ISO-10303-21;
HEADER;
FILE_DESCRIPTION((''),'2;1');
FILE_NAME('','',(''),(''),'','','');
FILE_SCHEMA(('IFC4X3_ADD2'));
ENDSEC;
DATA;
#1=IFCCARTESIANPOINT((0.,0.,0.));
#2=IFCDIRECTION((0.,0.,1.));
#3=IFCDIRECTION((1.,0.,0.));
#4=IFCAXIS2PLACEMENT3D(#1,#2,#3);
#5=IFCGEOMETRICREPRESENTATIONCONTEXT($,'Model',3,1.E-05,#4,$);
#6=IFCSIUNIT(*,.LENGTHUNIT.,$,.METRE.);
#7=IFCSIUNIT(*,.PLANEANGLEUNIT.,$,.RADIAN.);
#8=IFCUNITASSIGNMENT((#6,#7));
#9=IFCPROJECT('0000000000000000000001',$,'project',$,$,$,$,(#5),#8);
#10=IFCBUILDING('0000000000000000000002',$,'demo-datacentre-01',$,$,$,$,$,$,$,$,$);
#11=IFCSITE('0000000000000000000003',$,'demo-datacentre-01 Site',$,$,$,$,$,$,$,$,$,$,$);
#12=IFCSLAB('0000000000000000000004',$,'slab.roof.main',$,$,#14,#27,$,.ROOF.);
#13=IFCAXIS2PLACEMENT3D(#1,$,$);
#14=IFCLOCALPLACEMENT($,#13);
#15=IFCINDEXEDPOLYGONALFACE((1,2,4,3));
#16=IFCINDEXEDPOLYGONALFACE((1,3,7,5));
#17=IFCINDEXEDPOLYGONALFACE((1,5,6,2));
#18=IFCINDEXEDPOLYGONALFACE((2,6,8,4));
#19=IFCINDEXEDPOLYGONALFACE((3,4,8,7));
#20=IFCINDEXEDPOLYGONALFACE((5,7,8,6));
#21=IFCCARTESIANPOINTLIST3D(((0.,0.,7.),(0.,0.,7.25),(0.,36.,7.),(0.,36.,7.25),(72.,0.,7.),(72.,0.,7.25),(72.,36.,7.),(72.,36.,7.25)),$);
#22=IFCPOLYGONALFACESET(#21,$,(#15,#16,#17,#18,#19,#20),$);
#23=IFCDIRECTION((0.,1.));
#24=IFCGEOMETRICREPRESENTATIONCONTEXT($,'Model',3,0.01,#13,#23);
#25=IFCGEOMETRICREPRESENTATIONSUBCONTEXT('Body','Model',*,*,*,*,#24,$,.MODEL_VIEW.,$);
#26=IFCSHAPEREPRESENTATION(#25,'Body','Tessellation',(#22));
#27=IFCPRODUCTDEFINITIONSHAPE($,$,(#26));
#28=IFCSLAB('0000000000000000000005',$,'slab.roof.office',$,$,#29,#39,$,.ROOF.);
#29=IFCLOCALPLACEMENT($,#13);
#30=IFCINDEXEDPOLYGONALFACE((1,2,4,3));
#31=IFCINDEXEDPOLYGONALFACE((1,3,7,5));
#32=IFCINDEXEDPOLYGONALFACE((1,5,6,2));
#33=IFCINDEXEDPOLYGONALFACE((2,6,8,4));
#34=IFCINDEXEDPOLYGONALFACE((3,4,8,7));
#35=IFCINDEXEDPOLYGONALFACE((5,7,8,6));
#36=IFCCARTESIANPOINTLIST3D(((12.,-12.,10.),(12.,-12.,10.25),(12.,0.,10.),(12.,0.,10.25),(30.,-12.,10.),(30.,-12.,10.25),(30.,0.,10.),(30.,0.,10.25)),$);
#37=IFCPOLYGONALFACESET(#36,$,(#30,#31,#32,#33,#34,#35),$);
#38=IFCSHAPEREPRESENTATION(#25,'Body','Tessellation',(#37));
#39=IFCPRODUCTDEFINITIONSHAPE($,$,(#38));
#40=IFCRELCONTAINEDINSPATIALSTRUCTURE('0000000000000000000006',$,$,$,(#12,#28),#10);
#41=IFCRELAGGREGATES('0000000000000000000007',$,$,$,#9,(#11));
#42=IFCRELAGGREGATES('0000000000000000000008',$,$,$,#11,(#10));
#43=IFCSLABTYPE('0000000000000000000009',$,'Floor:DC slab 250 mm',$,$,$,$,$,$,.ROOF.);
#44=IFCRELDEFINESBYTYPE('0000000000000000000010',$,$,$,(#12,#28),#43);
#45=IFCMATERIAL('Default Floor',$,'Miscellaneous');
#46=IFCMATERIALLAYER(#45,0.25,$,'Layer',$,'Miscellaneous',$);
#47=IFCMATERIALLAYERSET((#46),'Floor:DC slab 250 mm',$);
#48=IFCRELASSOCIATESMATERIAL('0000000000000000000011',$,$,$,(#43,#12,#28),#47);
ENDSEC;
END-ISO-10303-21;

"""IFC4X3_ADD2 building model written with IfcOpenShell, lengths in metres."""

from ifc_helpers import new_model, si_unit, direction, frame, frame_2d, origin, origin_with_axes, origin_2d_with_axis, place, context, subcontext, project, spatial, rectangle, extrude, material, layer, layer_set, layer_usage, type_object, element, save


model = new_model("IFC4X3_ADD2")

# Units and contexts
model_context_1 = context("Model", 3, precision=0.01, world=origin(), true_north=direction((0.0, 1.0)))
model_context_2 = context("Model", 3, precision=1e-05, world=origin_with_axes())
body_context = subcontext(model_context_1, "Body", "Model", "MODEL_VIEW")
ifc_project = project(units=[si_unit("LENGTHUNIT", "METRE"), si_unit("PLANEANGLEUNIT", "RADIAN")], contexts=[model_context_2])

# Site, building
site = spatial("IfcSite", under=ifc_project, Name="demo-datacentre-01 Site")
building = spatial("IfcBuilding", under=site, Name="demo-datacentre-01")

# Slabs
ifc_material = material(Name="Default Floor", Category="Miscellaneous")
ifc_layer = layer(ifc_material, 0.25, Name="Layer", Category="Miscellaneous")
ifc_layer_set = layer_set([ifc_layer], Name="Floor:DC slab 250 mm")
ifc_layer_usage_1 = layer_usage(ifc_layer_set, "AXIS3", "POSITIVE", 0.0)
slab_type = type_object("IfcSlabType", Name="Floor:DC slab 250 mm", PredefinedType="ROOF", material=ifc_layer_set)
placement_1 = place(None, origin())
placement_2 = place(placement_1, origin())
placement_3 = place(placement_2, frame((0.0, 0.0, 7.0)))
slab_1_placement = place(placement_3, origin())
element("IfcSlab", 1, at=slab_1_placement, inside=building, type_object=slab_type, material=ifc_layer_usage_1, Name="slab.roof.main", PredefinedType="ROOF", context=body_context, shape_type="SweptSolid", body=[
    extrude(rectangle(XDim=36.0, YDim=72.0, at=origin_2d_with_axis()), frame((36.0, 18.0, 0.25), z_axis=(0.0, 0.0, -1.0), x_axis=(0.0, 1.0, 0.0)), (0.0, 0.0, 1.0), 0.25),
])
ifc_layer_usage_2 = layer_usage(ifc_layer_set, "AXIS3", "POSITIVE", 0.0)
placement_4 = place(placement_2, frame((0.0, 0.0, 10.0)))
slab_2_placement = place(placement_4, origin())
element("IfcSlab", 2, at=slab_2_placement, inside=building, type_object=slab_type, material=ifc_layer_usage_2, Name="slab.roof.office", PredefinedType="ROOF", context=body_context, shape_type="SweptSolid", body=[
    extrude(rectangle(XDim=12.0, YDim=18.0, at=frame_2d((0.0, 0.0), x_axis=(1.0, 0.0))), frame((21.0, -6.0, 0.25), z_axis=(0.0, 0.0, -1.0), x_axis=(0.0, 1.0, 0.0)), (0.0, 0.0, 1.0), 0.25),
])

save(model, "model.ifc")
